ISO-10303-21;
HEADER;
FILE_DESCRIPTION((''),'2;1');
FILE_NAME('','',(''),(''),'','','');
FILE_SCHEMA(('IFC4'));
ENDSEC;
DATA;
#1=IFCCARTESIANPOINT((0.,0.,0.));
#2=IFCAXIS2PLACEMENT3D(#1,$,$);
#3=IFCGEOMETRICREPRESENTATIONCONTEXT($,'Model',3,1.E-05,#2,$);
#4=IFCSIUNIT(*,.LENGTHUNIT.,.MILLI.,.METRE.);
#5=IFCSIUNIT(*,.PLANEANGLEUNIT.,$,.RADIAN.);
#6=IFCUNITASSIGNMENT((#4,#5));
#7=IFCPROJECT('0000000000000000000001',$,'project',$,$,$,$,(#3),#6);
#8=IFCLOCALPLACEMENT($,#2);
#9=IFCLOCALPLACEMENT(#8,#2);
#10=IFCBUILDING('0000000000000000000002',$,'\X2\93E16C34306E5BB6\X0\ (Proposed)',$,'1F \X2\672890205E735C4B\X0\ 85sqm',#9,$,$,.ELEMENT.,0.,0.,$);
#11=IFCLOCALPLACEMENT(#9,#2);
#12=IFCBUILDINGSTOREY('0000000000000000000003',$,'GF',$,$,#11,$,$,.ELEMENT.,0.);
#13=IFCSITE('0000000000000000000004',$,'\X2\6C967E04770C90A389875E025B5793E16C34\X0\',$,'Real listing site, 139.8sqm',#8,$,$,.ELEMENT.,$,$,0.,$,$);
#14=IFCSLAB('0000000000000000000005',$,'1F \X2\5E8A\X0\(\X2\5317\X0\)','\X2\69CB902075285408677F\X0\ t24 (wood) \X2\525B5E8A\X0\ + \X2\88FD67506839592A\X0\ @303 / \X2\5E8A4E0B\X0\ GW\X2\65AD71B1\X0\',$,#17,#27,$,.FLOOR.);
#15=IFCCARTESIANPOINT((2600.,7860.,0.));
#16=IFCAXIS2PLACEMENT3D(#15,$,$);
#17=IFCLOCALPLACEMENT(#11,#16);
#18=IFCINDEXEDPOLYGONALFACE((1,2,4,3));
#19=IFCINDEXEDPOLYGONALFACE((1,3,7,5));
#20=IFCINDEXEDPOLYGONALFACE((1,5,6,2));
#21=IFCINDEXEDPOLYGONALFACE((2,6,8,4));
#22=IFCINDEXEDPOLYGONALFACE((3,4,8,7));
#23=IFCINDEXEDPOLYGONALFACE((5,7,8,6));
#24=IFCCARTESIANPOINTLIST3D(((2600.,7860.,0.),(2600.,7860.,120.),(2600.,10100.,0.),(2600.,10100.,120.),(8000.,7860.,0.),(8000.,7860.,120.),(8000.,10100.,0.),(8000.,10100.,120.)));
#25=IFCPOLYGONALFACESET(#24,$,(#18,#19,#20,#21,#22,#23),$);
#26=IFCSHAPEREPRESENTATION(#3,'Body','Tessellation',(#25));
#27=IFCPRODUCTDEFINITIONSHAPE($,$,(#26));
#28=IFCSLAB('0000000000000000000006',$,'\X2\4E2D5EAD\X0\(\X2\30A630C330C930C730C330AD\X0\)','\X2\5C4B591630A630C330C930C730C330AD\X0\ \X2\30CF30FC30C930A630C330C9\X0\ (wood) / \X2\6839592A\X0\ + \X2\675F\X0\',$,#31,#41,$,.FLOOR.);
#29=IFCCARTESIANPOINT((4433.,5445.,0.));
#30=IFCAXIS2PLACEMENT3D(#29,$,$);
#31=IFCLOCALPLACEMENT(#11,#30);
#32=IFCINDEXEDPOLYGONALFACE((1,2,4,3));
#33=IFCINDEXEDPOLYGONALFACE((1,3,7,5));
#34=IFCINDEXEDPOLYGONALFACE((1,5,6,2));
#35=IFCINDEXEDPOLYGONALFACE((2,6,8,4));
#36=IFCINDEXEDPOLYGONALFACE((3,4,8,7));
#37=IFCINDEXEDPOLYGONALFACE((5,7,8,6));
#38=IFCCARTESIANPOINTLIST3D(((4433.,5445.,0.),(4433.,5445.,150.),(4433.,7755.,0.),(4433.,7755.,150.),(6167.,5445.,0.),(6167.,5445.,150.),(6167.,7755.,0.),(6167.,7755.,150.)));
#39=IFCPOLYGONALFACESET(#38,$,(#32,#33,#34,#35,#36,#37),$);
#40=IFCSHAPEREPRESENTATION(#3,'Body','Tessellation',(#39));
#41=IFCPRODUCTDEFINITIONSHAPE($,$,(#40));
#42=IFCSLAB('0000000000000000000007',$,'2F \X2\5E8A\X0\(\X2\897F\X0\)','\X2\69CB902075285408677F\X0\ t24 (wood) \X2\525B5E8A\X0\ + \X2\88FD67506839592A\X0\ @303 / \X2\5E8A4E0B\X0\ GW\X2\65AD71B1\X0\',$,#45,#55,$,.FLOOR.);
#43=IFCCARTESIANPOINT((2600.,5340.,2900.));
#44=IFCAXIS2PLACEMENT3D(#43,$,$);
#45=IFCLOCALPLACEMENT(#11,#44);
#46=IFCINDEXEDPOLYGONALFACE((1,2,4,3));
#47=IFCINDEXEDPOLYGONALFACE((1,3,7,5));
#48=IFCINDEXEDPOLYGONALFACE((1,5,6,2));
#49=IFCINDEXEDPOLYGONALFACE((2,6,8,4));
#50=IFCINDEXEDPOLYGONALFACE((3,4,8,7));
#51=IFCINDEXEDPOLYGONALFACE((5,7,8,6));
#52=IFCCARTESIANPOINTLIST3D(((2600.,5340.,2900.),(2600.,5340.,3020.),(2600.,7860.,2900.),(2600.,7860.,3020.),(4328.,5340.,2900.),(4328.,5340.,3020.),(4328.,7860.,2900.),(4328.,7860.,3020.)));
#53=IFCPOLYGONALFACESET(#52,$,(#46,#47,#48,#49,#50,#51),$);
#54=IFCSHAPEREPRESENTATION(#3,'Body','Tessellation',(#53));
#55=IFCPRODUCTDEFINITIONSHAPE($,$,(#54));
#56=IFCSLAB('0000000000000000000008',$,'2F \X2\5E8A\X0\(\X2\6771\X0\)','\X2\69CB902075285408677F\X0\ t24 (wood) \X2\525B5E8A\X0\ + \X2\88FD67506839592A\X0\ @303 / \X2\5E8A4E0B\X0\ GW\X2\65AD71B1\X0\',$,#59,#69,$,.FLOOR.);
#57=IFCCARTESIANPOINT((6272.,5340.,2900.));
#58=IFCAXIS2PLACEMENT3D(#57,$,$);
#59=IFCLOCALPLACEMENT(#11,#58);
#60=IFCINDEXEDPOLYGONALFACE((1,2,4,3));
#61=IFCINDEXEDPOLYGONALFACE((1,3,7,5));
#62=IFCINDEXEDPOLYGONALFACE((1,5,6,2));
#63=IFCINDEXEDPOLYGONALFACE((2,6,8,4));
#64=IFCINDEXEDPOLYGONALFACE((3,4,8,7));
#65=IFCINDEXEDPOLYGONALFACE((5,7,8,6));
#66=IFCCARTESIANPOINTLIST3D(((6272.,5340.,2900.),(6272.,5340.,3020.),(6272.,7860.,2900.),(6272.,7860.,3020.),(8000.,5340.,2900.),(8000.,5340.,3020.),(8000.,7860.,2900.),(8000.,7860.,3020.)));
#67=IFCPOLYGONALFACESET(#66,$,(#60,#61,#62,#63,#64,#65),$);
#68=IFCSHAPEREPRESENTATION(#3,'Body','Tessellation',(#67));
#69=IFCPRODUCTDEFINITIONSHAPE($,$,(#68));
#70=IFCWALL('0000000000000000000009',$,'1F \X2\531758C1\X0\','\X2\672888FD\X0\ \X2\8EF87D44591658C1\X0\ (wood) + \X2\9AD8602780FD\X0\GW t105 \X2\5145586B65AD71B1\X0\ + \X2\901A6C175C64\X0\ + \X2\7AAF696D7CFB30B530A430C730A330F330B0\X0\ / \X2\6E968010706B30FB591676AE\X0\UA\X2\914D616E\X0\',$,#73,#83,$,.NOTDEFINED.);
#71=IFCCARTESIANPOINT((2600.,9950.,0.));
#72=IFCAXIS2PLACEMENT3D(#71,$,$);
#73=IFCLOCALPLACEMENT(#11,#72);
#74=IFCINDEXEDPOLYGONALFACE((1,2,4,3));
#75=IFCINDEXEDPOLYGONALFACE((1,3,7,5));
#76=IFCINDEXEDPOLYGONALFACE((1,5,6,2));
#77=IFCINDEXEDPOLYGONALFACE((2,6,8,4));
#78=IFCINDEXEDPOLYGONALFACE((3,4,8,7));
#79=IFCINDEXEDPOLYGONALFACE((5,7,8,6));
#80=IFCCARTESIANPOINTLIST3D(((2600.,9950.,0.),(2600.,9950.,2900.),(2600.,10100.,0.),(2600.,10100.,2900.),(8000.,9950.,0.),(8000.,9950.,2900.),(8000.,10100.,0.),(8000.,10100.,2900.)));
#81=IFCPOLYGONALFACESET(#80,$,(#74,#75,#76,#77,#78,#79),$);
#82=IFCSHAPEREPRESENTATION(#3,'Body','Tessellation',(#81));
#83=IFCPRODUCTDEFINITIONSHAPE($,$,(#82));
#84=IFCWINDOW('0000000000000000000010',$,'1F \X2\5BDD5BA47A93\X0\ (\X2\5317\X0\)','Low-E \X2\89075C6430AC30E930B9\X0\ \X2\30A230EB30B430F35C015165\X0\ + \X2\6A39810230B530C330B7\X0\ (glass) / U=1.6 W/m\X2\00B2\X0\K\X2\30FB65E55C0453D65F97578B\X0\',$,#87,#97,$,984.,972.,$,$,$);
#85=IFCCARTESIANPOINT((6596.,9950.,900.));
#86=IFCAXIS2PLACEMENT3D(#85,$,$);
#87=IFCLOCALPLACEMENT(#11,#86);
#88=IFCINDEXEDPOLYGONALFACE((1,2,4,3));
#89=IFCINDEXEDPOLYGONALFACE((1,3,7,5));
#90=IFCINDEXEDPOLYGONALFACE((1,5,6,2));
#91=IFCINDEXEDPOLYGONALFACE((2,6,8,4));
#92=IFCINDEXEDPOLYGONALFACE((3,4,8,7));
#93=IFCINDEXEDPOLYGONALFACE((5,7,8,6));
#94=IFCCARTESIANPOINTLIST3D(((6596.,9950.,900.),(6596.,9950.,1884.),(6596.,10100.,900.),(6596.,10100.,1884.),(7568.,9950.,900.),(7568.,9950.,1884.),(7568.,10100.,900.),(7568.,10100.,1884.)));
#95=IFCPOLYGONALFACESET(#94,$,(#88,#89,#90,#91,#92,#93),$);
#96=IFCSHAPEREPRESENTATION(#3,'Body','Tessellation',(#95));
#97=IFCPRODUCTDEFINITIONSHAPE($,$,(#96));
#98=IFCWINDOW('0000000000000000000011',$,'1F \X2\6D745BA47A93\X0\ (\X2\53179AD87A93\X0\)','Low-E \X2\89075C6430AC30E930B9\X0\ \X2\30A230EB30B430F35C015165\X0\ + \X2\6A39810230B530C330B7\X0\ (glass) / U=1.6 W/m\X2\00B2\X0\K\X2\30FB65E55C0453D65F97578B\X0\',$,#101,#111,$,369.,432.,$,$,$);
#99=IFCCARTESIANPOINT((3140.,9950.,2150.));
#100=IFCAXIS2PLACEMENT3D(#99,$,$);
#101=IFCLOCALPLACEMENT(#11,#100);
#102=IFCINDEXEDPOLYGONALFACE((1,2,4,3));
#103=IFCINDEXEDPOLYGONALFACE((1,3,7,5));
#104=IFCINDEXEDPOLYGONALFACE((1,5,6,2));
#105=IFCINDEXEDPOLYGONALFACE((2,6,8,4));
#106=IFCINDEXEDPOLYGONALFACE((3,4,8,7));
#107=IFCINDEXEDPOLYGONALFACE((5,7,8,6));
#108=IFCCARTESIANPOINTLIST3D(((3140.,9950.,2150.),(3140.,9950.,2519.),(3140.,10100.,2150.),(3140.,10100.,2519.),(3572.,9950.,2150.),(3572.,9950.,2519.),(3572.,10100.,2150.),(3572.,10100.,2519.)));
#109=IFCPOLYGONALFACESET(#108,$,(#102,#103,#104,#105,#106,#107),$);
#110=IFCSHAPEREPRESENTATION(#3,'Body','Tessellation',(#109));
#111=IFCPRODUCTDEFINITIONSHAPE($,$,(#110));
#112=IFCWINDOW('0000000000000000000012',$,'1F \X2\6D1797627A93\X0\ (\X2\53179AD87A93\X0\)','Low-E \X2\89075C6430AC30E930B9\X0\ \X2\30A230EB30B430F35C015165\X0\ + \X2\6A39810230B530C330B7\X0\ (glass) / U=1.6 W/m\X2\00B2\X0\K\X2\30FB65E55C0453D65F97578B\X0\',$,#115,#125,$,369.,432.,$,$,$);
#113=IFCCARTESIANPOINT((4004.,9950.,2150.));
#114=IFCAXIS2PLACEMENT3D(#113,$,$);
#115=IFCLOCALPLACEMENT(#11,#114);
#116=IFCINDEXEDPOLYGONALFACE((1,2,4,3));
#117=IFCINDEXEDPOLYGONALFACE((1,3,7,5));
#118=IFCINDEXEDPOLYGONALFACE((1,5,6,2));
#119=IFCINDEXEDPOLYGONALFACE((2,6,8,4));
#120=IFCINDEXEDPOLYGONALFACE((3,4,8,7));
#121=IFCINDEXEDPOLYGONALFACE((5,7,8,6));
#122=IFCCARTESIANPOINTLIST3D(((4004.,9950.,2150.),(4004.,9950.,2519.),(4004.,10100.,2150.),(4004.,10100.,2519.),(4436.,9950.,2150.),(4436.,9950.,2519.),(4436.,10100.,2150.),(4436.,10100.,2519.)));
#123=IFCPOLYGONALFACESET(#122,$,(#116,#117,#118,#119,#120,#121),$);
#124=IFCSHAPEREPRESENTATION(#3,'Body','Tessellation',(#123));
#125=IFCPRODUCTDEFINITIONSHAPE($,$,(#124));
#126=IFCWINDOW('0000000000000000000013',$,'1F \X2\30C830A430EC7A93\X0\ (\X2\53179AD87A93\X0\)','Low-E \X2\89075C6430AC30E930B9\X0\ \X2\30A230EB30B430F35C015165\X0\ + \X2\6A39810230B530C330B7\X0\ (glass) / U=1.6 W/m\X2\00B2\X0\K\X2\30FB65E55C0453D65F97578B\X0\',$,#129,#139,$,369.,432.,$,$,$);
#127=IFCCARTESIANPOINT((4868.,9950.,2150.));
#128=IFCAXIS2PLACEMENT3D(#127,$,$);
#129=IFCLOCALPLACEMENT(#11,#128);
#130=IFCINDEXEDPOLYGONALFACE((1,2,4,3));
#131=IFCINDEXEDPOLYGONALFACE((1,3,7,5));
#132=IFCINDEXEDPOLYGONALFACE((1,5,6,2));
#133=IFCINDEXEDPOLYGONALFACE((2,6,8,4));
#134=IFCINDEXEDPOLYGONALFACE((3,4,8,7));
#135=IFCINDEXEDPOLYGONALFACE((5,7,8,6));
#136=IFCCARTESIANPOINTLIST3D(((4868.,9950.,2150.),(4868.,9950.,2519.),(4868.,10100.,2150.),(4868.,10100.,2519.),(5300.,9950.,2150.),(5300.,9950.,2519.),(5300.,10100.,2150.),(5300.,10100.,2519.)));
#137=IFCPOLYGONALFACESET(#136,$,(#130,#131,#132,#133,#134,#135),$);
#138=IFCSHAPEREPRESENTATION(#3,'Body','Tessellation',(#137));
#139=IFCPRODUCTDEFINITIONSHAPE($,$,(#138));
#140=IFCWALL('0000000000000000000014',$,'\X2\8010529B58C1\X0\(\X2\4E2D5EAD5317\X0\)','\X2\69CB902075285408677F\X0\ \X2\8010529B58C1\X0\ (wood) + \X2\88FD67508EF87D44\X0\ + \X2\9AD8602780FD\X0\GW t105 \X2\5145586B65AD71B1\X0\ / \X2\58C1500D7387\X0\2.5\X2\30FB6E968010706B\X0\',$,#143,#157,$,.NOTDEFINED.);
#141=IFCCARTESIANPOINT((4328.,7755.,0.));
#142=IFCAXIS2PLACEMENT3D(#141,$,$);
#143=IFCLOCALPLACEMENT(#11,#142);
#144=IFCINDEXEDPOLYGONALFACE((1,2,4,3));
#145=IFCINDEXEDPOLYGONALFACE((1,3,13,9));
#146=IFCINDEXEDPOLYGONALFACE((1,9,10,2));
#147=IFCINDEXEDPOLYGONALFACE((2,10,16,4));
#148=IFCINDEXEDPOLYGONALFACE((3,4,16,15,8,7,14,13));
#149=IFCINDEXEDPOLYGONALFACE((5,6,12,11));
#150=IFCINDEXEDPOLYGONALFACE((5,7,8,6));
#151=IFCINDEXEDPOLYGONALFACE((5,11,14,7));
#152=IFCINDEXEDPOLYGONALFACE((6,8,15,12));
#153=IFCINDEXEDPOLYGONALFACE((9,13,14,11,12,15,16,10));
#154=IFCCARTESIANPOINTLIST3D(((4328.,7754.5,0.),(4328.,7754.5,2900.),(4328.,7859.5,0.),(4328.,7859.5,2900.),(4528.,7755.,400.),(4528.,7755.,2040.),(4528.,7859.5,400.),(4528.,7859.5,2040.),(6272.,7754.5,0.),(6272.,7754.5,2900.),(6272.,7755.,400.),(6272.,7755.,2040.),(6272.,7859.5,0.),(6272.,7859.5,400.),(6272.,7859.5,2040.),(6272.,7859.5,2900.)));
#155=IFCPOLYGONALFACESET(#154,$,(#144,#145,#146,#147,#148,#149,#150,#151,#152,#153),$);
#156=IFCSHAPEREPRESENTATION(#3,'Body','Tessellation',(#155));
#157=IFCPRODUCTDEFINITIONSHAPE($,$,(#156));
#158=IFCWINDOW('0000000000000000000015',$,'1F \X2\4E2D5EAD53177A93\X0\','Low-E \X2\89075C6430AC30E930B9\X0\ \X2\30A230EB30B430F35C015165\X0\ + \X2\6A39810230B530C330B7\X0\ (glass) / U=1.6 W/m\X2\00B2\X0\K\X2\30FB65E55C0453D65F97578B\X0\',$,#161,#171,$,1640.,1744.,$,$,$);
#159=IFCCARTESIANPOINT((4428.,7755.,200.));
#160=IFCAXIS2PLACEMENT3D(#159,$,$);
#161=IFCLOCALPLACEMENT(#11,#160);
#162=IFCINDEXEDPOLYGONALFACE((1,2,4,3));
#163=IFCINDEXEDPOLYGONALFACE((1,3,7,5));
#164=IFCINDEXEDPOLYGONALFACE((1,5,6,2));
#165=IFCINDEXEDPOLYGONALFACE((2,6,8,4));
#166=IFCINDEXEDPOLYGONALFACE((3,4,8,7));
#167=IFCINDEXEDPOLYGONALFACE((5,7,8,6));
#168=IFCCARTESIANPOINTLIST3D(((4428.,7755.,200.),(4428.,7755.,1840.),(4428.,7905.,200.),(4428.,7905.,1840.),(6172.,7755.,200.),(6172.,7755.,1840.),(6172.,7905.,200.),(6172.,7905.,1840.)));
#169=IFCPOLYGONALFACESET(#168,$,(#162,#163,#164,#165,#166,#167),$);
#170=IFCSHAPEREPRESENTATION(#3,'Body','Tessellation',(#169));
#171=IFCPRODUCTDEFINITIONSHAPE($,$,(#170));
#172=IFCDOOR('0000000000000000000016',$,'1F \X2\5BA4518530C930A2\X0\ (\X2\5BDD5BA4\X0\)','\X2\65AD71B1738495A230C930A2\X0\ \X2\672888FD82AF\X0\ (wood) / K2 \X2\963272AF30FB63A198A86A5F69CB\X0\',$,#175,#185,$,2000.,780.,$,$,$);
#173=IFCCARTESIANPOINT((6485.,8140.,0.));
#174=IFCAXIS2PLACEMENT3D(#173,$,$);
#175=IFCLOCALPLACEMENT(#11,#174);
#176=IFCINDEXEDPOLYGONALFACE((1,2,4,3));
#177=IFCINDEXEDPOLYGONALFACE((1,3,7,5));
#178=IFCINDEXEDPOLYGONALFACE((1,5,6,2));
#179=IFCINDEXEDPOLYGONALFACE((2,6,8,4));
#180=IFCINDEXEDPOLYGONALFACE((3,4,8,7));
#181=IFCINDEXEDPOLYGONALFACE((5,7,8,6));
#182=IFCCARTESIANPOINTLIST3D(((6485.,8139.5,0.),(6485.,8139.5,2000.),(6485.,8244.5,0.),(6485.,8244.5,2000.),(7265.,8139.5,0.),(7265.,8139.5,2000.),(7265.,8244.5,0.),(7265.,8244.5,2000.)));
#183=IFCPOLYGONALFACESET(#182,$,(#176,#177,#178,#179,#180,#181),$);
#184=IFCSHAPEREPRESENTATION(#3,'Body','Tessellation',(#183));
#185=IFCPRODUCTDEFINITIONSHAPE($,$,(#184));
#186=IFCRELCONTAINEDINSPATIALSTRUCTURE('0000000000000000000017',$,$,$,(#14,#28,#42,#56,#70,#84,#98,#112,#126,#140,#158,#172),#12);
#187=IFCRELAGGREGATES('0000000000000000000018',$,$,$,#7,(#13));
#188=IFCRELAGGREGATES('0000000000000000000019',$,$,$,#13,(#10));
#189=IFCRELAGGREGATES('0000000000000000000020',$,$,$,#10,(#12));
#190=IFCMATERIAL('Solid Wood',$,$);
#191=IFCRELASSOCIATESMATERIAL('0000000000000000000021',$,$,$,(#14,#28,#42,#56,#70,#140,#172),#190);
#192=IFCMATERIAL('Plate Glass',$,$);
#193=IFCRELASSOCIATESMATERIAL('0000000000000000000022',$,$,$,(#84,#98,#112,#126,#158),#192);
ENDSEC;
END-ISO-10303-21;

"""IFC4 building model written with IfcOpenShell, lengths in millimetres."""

from ifc_helpers import new_model, si_unit, frame, frame_2d, origin, place, context, project, spatial, rectangle, extrude, material, element, fill, save


model = new_model("IFC4")

# Units and contexts
model_context = context("Model", 3, precision=1e-05, world=origin())
ifc_project = project(units=[si_unit("LENGTHUNIT", "METRE", prefix="MILLI"), si_unit("PLANEANGLEUNIT", "RADIAN")], contexts=[model_context])

# Site, building, storey
site_placement = place(None, origin())
site = spatial("IfcSite", under=ifc_project, at=site_placement, Name="沖縄県那覇市字鏡水", ObjectType="Real listing site, 139.8sqm", CompositionType="ELEMENT", RefElevation=0.0)
building_placement = place(site_placement, origin())
building = spatial("IfcBuilding", under=site, at=building_placement, Name="鏡水の家 (Proposed)", ObjectType="1F 木造平屋 85sqm", CompositionType="ELEMENT", ElevationOfRefHeight=0.0, ElevationOfTerrain=0.0)
storey_placement = place(building_placement, origin())
storey = spatial("IfcBuildingStorey", under=building, at=storey_placement, Name="GF", CompositionType="ELEMENT", Elevation=0.0)

# Slabs
ifc_material_1 = material(Name="Solid Wood")
slab_1_placement = place(storey_placement, frame((2600.0, 7860.0, 0.0)))
element("IfcSlab", 1, at=slab_1_placement, inside=storey, material=ifc_material_1, Name="1F 床(北)", Description="構造用合板 t24 (wood) 剛床 + 製材根太 @303 / 床下 GW断熱", PredefinedType="FLOOR", context=model_context, shape_type="SweptSolid", body=[
    extrude(rectangle(XDim=5400.0, YDim=2240.0, at=frame_2d((2700.0, 1120.0))), frame((2600.0, 7860.0, 0.0)), (0.0, 0.0, 1.0), 120.0),
])
slab_2_placement = place(storey_placement, frame((4433.0, 5445.0, 0.0)))
element("IfcSlab", 2, at=slab_2_placement, inside=storey, material=ifc_material_1, Name="中庭(ウッドデッキ)", Description="屋外ウッドデッキ ハードウッド (wood) / 根太 + 束", PredefinedType="FLOOR", context=model_context, shape_type="SweptSolid", body=[
    extrude(rectangle(XDim=1734.0, YDim=2310.0, at=frame_2d((867.0, 1155.0))), frame((4433.0, 5445.0, 0.0)), (0.0, 0.0, 1.0), 150.0),
])
slab_3_placement = place(storey_placement, frame((2600.0, 5340.0, 2900.0)))
element("IfcSlab", 3, at=slab_3_placement, inside=storey, material=ifc_material_1, Name="2F 床(西)", Description="構造用合板 t24 (wood) 剛床 + 製材根太 @303 / 床下 GW断熱", PredefinedType="FLOOR", context=model_context, shape_type="SweptSolid", body=[
    extrude(rectangle(XDim=1728.0, YDim=2520.0, at=frame_2d((864.0, 1260.0))), frame((2600.0, 5340.0, 2900.0)), (0.0, 0.0, 1.0), 120.0),
])
slab_4_placement = place(storey_placement, frame((6272.0, 5340.0, 2900.0)))
element("IfcSlab", 4, at=slab_4_placement, inside=storey, material=ifc_material_1, Name="2F 床(東)", Description="構造用合板 t24 (wood) 剛床 + 製材根太 @303 / 床下 GW断熱", PredefinedType="FLOOR", context=model_context, shape_type="SweptSolid", body=[
    extrude(rectangle(XDim=1728.0, YDim=2520.0, at=frame_2d((864.0, 1260.0))), frame((6272.0, 5340.0, 2900.0)), (0.0, 0.0, 1.0), 120.0),
])

# Wall, openings, windows
wall_1_placement = place(storey_placement, frame((2600.0, 9950.0, 0.0)))
wall_1 = element("IfcWall", 5, at=wall_1_placement, inside=storey, material=ifc_material_1, Name="1F 北壁", Description="木製 軸組外壁 (wood) + 高性能GW t105 充填断熱 + 通気層 + 窯業系サイディング / 準耐火・外皮UA配慮", PredefinedType="NOTDEFINED", context=model_context, shape_type="SweptSolid", body=[
    extrude(rectangle(XDim=5400.0, YDim=150.0, at=frame_2d((2700.0, 75.0))), frame((2600.0, 9950.0, 0.0)), (0.0, 0.0, 1.0), 2900.0),
])
opening_1_placement = place(storey_placement, frame((6596.0, 9950.0, 900.0)))
opening_1 = element("IfcOpeningElement", 6, at=opening_1_placement, cuts=wall_1, PredefinedType="NOTDEFINED", context=model_context, shape_type="SweptSolid", body=[
    extrude(rectangle(XDim=972.0, YDim=150.0, at=frame_2d((486.0, 75.0))), frame((6596.0, 9950.0, 900.0)), (0.0, 0.0, 1.0), 984.0),
])
opening_2_placement = place(storey_placement, frame((3140.0, 9950.0, 2150.0)))
opening_2 = element("IfcOpeningElement", 7, at=opening_2_placement, cuts=wall_1, PredefinedType="NOTDEFINED", context=model_context, shape_type="SweptSolid", body=[
    extrude(rectangle(XDim=432.0, YDim=150.0, at=frame_2d((216.0, 75.0))), frame((3140.0, 9950.0, 2150.0)), (0.0, 0.0, 1.0), 369.0),
])
opening_3_placement = place(storey_placement, frame((4004.0, 9950.0, 2150.0)))
opening_3 = element("IfcOpeningElement", 8, at=opening_3_placement, cuts=wall_1, PredefinedType="NOTDEFINED", context=model_context, shape_type="SweptSolid", body=[
    extrude(rectangle(XDim=432.0, YDim=150.0, at=frame_2d((216.0, 75.0))), frame((4004.0, 9950.0, 2150.0)), (0.0, 0.0, 1.0), 369.0),
])
opening_4_placement = place(storey_placement, frame((4868.0, 9950.0, 2150.0)))
opening_4 = element("IfcOpeningElement", 9, at=opening_4_placement, cuts=wall_1, PredefinedType="NOTDEFINED", context=model_context, shape_type="SweptSolid", body=[
    extrude(rectangle(XDim=432.0, YDim=150.0, at=frame_2d((216.0, 75.0))), frame((4868.0, 9950.0, 2150.0)), (0.0, 0.0, 1.0), 369.0),
])
ifc_material_2 = material(Name="Plate Glass")
window_1_placement = place(storey_placement, frame((6596.0, 9950.0, 900.0)))
window_1 = element("IfcWindow", 10, at=window_1_placement, inside=storey, material=ifc_material_2, Name="1F 寝室窓 (北)", Description="Low-E 複層ガラス アルゴン封入 + 樹脂サッシ (glass) / U=1.6 W/m²K・日射取得型", OverallHeight=984.0, OverallWidth=972.0, context=model_context, shape_type="SweptSolid", body=[
    extrude(rectangle(XDim=972.0, YDim=150.0, at=frame_2d((486.0, 75.0))), frame((6596.0, 9950.0, 900.0)), (0.0, 0.0, 1.0), 984.0),
])
fill(opening_1, window_1)
window_2_placement = place(storey_placement, frame((3140.0, 9950.0, 2150.0)))
window_2 = element("IfcWindow", 11, at=window_2_placement, inside=storey, material=ifc_material_2, Name="1F 浴室窓 (北高窓)", Description="Low-E 複層ガラス アルゴン封入 + 樹脂サッシ (glass) / U=1.6 W/m²K・日射取得型", OverallHeight=369.0, OverallWidth=432.0, context=model_context, shape_type="SweptSolid", body=[
    extrude(rectangle(XDim=432.0, YDim=150.0, at=frame_2d((216.0, 75.0))), frame((3140.0, 9950.0, 2150.0)), (0.0, 0.0, 1.0), 369.0),
])
fill(opening_2, window_2)
window_3_placement = place(storey_placement, frame((4004.0, 9950.0, 2150.0)))
window_3 = element("IfcWindow", 12, at=window_3_placement, inside=storey, material=ifc_material_2, Name="1F 洗面窓 (北高窓)", Description="Low-E 複層ガラス アルゴン封入 + 樹脂サッシ (glass) / U=1.6 W/m²K・日射取得型", OverallHeight=369.0, OverallWidth=432.0, context=model_context, shape_type="SweptSolid", body=[
    extrude(rectangle(XDim=432.0, YDim=150.0, at=frame_2d((216.0, 75.0))), frame((4004.0, 9950.0, 2150.0)), (0.0, 0.0, 1.0), 369.0),
])
fill(opening_3, window_3)
window_4_placement = place(storey_placement, frame((4868.0, 9950.0, 2150.0)))
window_4 = element("IfcWindow", 13, at=window_4_placement, inside=storey, material=ifc_material_2, Name="1F トイレ窓 (北高窓)", Description="Low-E 複層ガラス アルゴン封入 + 樹脂サッシ (glass) / U=1.6 W/m²K・日射取得型", OverallHeight=369.0, OverallWidth=432.0, context=model_context, shape_type="SweptSolid", body=[
    extrude(rectangle(XDim=432.0, YDim=150.0, at=frame_2d((216.0, 75.0))), frame((4868.0, 9950.0, 2150.0)), (0.0, 0.0, 1.0), 369.0),
])
fill(opening_4, window_4)

# Wall, opening, window
wall_2_placement = place(storey_placement, frame((4328.0, 7755.0, 0.0)))
wall_2 = element("IfcWall", 14, at=wall_2_placement, inside=storey, material=ifc_material_1, Name="耐力壁(中庭北)", Description="構造用合板 耐力壁 (wood) + 製材軸組 + 高性能GW t105 充填断熱 / 壁倍率2.5・準耐火", PredefinedType="NOTDEFINED", context=model_context, shape_type="SweptSolid", body=[
    extrude(rectangle(XDim=1944.0, YDim=105.0, at=frame_2d((972.0, 52.0))), frame((4328.0, 7755.0, 0.0)), (0.0, 0.0, 1.0), 2900.0),
])
opening_5_placement = place(storey_placement, frame((4428.0, 7755.0, 200.0)))
opening_5 = element("IfcOpeningElement", 15, at=opening_5_placement, cuts=wall_2, PredefinedType="NOTDEFINED", context=model_context, shape_type="SweptSolid", body=[
    extrude(rectangle(XDim=1744.0, YDim=150.0, at=frame_2d((872.0, 75.0))), frame((4428.0, 7755.0, 200.0)), (0.0, 0.0, 1.0), 1640.0),
])
window_5_placement = place(storey_placement, frame((4428.0, 7755.0, 200.0)))
window_5 = element("IfcWindow", 16, at=window_5_placement, inside=storey, material=ifc_material_2, Name="1F 中庭北窓", Description="Low-E 複層ガラス アルゴン封入 + 樹脂サッシ (glass) / U=1.6 W/m²K・日射取得型", OverallHeight=1640.0, OverallWidth=1744.0, context=model_context, shape_type="SweptSolid", body=[
    extrude(rectangle(XDim=1744.0, YDim=150.0, at=frame_2d((872.0, 75.0))), frame((4428.0, 7755.0, 200.0)), (0.0, 0.0, 1.0), 1640.0),
])
fill(opening_5, window_5)

# Door
door_1_placement = place(storey_placement, frame((6485.0, 8140.0, 0.0)))
element("IfcDoor", 17, at=door_1_placement, inside=storey, material=ifc_material_1, Name="1F 室内ドア (寝室)", Description="断熱玄関ドア 木製芯 (wood) / K2 防犯・採風機構", OverallHeight=2000.0, OverallWidth=780.0, context=model_context, shape_type="SweptSolid", body=[
    extrude(rectangle(XDim=780.0, YDim=105.0, at=frame_2d((390.0, 52.0))), frame((6485.0, 8140.0, 0.0)), (0.0, 0.0, 1.0), 2000.0),
])

save(model, "model.ifc")
